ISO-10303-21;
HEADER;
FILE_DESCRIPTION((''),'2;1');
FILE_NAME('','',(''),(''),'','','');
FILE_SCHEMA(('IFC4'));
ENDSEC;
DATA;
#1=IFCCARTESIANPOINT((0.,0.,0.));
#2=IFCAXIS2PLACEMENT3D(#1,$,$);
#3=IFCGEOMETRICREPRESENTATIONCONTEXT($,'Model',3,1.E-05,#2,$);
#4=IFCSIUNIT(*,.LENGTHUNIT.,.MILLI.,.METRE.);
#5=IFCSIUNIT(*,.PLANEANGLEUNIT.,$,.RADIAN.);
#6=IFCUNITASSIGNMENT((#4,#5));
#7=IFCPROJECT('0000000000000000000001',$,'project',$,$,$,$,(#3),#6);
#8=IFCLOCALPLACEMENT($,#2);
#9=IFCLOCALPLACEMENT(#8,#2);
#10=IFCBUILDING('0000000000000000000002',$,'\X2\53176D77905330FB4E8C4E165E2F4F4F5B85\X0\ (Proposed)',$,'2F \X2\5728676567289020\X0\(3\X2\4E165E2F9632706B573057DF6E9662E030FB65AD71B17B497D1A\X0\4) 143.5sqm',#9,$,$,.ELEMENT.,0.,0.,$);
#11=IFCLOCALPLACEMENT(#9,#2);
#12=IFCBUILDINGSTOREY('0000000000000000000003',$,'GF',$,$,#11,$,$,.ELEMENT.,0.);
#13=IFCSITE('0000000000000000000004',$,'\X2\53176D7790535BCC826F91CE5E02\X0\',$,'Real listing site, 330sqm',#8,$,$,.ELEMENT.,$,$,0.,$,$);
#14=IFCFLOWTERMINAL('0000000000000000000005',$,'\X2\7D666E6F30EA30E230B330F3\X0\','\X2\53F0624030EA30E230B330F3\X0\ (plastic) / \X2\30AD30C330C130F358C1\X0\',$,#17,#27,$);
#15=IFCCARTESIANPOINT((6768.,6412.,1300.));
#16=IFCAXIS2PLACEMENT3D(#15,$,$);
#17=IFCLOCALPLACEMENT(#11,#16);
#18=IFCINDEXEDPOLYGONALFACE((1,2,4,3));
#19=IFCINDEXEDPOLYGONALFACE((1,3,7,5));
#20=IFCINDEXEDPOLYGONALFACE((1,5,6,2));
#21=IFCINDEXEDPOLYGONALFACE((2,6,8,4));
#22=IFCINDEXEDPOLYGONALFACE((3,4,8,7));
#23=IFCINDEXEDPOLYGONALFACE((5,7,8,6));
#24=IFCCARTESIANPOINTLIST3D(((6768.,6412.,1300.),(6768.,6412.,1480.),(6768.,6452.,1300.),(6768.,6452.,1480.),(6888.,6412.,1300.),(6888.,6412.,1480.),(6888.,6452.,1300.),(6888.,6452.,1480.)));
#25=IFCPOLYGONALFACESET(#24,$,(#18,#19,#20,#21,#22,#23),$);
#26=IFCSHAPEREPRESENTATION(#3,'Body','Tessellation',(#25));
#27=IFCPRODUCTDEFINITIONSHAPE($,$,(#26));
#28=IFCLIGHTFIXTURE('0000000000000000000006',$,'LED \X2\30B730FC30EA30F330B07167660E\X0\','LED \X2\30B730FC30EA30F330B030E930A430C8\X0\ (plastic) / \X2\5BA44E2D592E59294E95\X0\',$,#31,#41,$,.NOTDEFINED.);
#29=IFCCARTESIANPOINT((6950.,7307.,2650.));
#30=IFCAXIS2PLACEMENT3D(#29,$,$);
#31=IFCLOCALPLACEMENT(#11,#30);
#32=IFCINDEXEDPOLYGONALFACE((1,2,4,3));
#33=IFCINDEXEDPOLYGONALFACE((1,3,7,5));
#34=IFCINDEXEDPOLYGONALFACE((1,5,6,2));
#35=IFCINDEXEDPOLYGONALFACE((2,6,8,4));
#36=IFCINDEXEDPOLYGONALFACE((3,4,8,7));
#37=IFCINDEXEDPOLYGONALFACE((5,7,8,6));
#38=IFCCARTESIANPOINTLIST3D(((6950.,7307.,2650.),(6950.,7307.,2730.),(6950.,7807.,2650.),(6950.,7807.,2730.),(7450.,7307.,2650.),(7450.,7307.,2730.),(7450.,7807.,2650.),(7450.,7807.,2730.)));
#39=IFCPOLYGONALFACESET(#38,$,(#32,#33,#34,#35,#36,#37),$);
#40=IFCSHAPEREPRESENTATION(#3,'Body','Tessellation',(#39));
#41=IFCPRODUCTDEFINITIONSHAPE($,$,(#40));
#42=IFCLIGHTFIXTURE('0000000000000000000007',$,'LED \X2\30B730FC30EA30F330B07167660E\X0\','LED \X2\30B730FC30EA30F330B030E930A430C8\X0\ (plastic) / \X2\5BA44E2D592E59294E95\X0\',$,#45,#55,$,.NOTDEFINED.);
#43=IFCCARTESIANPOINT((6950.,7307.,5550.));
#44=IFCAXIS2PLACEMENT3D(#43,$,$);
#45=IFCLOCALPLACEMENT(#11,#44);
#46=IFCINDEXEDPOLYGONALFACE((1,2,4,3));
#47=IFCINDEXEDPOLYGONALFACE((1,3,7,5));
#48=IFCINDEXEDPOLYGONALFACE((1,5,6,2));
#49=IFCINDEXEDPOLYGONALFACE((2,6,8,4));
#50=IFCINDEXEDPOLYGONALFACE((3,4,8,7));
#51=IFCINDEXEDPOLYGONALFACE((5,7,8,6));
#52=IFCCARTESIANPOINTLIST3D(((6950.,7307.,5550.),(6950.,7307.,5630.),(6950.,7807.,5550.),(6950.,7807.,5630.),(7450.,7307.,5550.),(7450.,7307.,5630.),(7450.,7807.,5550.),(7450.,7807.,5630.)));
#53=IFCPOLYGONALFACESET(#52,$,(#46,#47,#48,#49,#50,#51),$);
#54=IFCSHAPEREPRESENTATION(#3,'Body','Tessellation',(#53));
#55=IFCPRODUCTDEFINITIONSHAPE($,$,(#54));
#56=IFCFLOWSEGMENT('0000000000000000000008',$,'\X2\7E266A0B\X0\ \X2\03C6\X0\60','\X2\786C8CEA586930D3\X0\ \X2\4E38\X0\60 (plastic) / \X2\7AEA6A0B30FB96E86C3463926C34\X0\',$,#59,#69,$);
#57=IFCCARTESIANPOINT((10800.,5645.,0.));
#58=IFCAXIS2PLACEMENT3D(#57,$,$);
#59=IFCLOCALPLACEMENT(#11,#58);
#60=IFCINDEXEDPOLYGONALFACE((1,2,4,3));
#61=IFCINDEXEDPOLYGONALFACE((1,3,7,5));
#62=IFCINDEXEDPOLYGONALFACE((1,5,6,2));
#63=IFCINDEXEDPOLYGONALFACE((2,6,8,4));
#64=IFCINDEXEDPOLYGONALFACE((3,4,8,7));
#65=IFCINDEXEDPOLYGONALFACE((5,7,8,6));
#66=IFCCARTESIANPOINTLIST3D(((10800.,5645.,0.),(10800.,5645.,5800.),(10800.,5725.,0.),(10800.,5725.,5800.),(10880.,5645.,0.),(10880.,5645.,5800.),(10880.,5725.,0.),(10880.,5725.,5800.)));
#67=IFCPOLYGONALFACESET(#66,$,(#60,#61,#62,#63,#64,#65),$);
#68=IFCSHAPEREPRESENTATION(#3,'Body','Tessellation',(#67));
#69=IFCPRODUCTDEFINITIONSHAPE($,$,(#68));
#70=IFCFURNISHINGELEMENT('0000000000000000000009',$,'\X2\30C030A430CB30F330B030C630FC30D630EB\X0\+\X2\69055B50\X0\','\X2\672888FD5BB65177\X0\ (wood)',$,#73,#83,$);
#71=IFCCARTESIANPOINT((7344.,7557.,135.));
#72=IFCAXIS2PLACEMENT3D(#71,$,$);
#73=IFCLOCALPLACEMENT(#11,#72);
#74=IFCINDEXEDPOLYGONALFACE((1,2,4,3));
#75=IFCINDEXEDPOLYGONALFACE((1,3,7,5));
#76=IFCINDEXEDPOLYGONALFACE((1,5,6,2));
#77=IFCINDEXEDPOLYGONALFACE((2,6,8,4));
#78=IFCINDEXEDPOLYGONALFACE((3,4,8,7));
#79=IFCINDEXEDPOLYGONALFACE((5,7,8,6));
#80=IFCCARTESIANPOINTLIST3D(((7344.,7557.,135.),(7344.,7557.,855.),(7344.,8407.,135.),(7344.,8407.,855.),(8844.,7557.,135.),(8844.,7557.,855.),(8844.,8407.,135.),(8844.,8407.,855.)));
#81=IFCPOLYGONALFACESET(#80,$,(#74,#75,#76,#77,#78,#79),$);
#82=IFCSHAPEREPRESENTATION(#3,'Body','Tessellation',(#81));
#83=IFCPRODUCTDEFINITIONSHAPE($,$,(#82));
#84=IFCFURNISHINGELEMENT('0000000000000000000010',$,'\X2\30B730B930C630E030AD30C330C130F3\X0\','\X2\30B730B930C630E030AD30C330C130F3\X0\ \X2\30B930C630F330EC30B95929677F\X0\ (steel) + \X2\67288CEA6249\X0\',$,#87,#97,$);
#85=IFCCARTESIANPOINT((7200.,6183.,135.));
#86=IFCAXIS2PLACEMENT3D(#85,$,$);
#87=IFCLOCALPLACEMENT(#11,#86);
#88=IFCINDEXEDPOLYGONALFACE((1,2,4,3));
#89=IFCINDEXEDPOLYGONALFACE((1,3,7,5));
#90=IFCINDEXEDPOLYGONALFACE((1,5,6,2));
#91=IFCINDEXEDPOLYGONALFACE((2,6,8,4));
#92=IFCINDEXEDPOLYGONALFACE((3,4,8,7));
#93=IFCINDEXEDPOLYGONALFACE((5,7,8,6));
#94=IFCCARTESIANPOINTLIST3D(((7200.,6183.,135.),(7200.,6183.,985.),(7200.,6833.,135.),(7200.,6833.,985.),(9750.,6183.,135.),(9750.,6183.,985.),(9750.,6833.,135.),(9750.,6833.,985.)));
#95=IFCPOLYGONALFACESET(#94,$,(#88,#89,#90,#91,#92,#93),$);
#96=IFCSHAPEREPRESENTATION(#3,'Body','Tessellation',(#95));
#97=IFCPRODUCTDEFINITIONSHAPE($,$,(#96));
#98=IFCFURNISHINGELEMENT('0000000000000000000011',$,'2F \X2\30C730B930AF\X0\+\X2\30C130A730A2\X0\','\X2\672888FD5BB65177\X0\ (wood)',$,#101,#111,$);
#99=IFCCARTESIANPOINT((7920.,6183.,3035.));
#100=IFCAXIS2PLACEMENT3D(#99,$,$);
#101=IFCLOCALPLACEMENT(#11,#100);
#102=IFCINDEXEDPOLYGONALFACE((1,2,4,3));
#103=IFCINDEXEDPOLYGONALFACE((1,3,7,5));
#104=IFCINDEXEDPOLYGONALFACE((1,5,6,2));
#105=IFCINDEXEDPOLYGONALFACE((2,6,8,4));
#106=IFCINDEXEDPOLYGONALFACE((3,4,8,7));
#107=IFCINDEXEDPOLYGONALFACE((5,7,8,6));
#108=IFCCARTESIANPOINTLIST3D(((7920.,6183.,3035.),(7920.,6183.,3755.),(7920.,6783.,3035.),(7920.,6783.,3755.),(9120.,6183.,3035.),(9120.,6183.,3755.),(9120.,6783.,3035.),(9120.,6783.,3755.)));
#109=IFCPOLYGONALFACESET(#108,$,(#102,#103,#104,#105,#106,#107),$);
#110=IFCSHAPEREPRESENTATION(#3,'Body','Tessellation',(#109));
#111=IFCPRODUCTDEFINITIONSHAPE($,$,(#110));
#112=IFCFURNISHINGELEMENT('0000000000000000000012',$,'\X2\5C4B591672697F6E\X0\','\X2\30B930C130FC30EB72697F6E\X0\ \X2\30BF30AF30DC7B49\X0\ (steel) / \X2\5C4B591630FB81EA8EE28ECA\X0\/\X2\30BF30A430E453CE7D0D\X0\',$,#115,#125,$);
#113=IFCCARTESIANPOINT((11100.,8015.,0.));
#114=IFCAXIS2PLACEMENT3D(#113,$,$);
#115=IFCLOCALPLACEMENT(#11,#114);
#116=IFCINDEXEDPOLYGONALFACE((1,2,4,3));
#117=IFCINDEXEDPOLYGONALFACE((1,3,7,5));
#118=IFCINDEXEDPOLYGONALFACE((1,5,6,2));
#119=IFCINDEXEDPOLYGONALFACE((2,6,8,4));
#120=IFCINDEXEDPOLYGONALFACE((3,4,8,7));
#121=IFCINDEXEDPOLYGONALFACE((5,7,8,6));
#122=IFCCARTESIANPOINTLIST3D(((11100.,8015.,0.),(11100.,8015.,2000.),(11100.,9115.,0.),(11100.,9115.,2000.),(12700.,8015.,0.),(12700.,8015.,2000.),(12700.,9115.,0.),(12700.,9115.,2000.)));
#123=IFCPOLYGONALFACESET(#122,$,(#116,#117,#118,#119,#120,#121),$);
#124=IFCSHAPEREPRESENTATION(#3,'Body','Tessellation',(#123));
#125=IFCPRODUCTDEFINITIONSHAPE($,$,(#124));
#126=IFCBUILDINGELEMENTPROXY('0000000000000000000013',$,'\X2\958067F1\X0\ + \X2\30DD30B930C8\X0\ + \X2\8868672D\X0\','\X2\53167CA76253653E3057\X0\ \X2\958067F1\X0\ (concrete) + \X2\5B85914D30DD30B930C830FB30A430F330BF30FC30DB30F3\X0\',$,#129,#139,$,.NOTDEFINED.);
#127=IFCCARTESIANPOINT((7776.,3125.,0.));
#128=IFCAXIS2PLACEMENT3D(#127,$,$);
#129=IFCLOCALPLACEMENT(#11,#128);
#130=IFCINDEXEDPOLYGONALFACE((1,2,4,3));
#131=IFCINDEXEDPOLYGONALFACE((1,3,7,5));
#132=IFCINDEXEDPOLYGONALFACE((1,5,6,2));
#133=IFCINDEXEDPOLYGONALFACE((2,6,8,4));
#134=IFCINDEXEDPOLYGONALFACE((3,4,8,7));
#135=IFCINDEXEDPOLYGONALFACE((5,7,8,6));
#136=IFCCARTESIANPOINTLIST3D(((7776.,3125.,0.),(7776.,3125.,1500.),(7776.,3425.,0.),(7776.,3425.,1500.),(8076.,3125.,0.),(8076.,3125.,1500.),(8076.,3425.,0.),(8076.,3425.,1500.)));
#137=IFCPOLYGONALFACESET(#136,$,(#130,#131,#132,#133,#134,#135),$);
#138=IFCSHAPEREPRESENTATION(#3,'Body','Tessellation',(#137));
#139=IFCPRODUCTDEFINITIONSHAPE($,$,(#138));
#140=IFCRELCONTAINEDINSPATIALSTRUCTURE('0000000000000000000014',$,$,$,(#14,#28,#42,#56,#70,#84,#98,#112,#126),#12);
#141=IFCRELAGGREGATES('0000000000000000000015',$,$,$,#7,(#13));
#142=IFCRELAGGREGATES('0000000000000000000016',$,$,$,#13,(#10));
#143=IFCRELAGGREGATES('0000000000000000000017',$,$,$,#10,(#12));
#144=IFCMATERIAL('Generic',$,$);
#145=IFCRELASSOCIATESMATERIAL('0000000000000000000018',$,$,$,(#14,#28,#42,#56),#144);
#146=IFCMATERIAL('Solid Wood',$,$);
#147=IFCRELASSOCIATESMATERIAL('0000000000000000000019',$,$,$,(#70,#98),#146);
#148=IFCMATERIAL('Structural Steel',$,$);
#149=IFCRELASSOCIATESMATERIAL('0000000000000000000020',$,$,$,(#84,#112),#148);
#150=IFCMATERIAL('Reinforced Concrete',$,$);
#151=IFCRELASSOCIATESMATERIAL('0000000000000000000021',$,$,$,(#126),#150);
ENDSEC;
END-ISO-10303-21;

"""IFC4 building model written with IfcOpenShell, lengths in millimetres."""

from ifc_helpers import new_model, si_unit, frame, frame_2d, origin, place, context, project, spatial, rectangle, extrude, material, element, save


model = new_model("IFC4")

# Units and contexts
model_context = context("Model", 3, precision=1e-05, world=origin())
ifc_project = project(units=[si_unit("LENGTHUNIT", "METRE", prefix="MILLI"), si_unit("PLANEANGLEUNIT", "RADIAN")], contexts=[model_context])

# Site, building, storey
site_placement = place(None, origin())
site = spatial("IfcSite", under=ifc_project, at=site_placement, Name="北海道富良野市", ObjectType="Real listing site, 330sqm", CompositionType="ELEMENT", RefElevation=0.0)
building_placement = place(site_placement, origin())
building = spatial("IfcBuilding", under=site, at=building_placement, Name="北海道・二世帯住宅 (Proposed)", ObjectType="2F 在来木造(3世帯防火地域準拠・断熱等級4) 143.5sqm", CompositionType="ELEMENT", ElevationOfRefHeight=0.0, ElevationOfTerrain=0.0)
storey_placement = place(building_placement, origin())
storey = spatial("IfcBuildingStorey", under=building, at=storey_placement, Name="GF", CompositionType="ELEMENT", Elevation=0.0)

# Shared definitions
ifc_material_1 = material(Name="Solid Wood")

# Shared definitions
ifc_material_2 = material(Name="Reinforced Concrete")

# Shared definitions
ifc_material_3 = material(Name="Structural Steel")

# Flow terminal
ifc_material_4 = material(Name="Generic")
flow_terminal_1_placement = place(storey_placement, frame((6768.0, 6412.0, 1300.0)))
element("IfcFlowTerminal", 1, at=flow_terminal_1_placement, inside=storey, material=ifc_material_4, Name="給湯リモコン", Description="台所リモコン (plastic) / キッチン壁", context=model_context, shape_type="SweptSolid", body=[
    extrude(rectangle(XDim=120.0, YDim=40.0, at=frame_2d((60.0, 20.0))), frame((6768.0, 6412.0, 1300.0)), (0.0, 0.0, 1.0), 180.0),
])

# Light fixtures
light_fixture_1_placement = place(storey_placement, frame((6950.0, 7307.0, 2650.0)))
element("IfcLightFixture", 2, at=light_fixture_1_placement, inside=storey, material=ifc_material_4, Name="LED シーリング照明", Description="LED シーリングライト (plastic) / 室中央天井", PredefinedType="NOTDEFINED", context=model_context, shape_type="SweptSolid", body=[
    extrude(rectangle(XDim=500.0, YDim=500.0, at=frame_2d((250.0, 250.0))), frame((6950.0, 7307.0, 2650.0)), (0.0, 0.0, 1.0), 80.0),
])
light_fixture_2_placement = place(storey_placement, frame((6950.0, 7307.0, 5550.0)))
element("IfcLightFixture", 3, at=light_fixture_2_placement, inside=storey, material=ifc_material_4, Name="LED シーリング照明", Description="LED シーリングライト (plastic) / 室中央天井", PredefinedType="NOTDEFINED", context=model_context, shape_type="SweptSolid", body=[
    extrude(rectangle(XDim=500.0, YDim=500.0, at=frame_2d((250.0, 250.0))), frame((6950.0, 7307.0, 5550.0)), (0.0, 0.0, 1.0), 80.0),
])

# Flow segment
flow_segment_placement = place(storey_placement, frame((10800.0, 5645.0, 0.0)))
element("IfcFlowSegment", 4, at=flow_segment_placement, inside=storey, material=ifc_material_4, Name="縦樋 φ60", Description="硬質塩ビ 丸60 (plastic) / 竪樋・雨水排水", context=model_context, shape_type="SweptSolid", body=[
    extrude(rectangle(XDim=80.0, YDim=80.0, at=frame_2d((40.0, 40.0))), frame((10800.0, 5645.0, 0.0)), (0.0, 0.0, 1.0), 5800.0),
])

# Furnishing elements
furnishing_1_placement = place(storey_placement, frame((7344.0, 7557.0, 135.0)))
element("IfcFurnishingElement", 5, at=furnishing_1_placement, inside=storey, material=ifc_material_1, Name="ダイニングテーブル+椅子", Description="木製家具 (wood)", context=model_context, shape_type="SweptSolid", body=[
    extrude(rectangle(XDim=1500.0, YDim=850.0, at=frame_2d((750.0, 425.0))), frame((7344.0, 7557.0, 135.0)), (0.0, 0.0, 1.0), 720.0),
])
furnishing_2_placement = place(storey_placement, frame((7200.0, 6183.0, 135.0)))
element("IfcFurnishingElement", 6, at=furnishing_2_placement, inside=storey, material=ifc_material_3, Name="システムキッチン", Description="システムキッチン ステンレス天板 (steel) + 木質扉", context=model_context, shape_type="SweptSolid", body=[
    extrude(rectangle(XDim=2550.0, YDim=650.0, at=frame_2d((1275.0, 325.0))), frame((7200.0, 6183.0, 135.0)), (0.0, 0.0, 1.0), 850.0),
])
furnishing_3_placement = place(storey_placement, frame((7920.0, 6183.0, 3035.0)))
element("IfcFurnishingElement", 7, at=furnishing_3_placement, inside=storey, material=ifc_material_1, Name="2F デスク+チェア", Description="木製家具 (wood)", context=model_context, shape_type="SweptSolid", body=[
    extrude(rectangle(XDim=1200.0, YDim=600.0, at=frame_2d((600.0, 300.0))), frame((7920.0, 6183.0, 3035.0)), (0.0, 0.0, 1.0), 720.0),
])
furnishing_4_placement = place(storey_placement, frame((11100.0, 8015.0, 0.0)))
element("IfcFurnishingElement", 8, at=furnishing_4_placement, inside=storey, material=ifc_material_3, Name="屋外物置", Description="スチール物置 タクボ等 (steel) / 屋外・自転車/タイヤ収納", context=model_context, shape_type="SweptSolid", body=[
    extrude(rectangle(XDim=1600.0, YDim=1100.0, at=frame_2d((800.0, 550.0))), frame((11100.0, 8015.0, 0.0)), (0.0, 0.0, 1.0), 2000.0),
])

# Building element proxy
proxy_placement = place(storey_placement, frame((7776.0, 3125.0, 0.0)))
element("IfcBuildingElementProxy", 9, at=proxy_placement, inside=storey, material=ifc_material_2, Name="門柱 + ポスト + 表札", Description="化粧打放し 門柱 (concrete) + 宅配ポスト・インターホン", PredefinedType="NOTDEFINED", context=model_context, shape_type="SweptSolid", body=[
    extrude(rectangle(XDim=300.0, YDim=300.0, at=frame_2d((150.0, 150.0))), frame((7776.0, 3125.0, 0.0)), (0.0, 0.0, 1.0), 1500.0),
])

save(model, "model.ifc")
